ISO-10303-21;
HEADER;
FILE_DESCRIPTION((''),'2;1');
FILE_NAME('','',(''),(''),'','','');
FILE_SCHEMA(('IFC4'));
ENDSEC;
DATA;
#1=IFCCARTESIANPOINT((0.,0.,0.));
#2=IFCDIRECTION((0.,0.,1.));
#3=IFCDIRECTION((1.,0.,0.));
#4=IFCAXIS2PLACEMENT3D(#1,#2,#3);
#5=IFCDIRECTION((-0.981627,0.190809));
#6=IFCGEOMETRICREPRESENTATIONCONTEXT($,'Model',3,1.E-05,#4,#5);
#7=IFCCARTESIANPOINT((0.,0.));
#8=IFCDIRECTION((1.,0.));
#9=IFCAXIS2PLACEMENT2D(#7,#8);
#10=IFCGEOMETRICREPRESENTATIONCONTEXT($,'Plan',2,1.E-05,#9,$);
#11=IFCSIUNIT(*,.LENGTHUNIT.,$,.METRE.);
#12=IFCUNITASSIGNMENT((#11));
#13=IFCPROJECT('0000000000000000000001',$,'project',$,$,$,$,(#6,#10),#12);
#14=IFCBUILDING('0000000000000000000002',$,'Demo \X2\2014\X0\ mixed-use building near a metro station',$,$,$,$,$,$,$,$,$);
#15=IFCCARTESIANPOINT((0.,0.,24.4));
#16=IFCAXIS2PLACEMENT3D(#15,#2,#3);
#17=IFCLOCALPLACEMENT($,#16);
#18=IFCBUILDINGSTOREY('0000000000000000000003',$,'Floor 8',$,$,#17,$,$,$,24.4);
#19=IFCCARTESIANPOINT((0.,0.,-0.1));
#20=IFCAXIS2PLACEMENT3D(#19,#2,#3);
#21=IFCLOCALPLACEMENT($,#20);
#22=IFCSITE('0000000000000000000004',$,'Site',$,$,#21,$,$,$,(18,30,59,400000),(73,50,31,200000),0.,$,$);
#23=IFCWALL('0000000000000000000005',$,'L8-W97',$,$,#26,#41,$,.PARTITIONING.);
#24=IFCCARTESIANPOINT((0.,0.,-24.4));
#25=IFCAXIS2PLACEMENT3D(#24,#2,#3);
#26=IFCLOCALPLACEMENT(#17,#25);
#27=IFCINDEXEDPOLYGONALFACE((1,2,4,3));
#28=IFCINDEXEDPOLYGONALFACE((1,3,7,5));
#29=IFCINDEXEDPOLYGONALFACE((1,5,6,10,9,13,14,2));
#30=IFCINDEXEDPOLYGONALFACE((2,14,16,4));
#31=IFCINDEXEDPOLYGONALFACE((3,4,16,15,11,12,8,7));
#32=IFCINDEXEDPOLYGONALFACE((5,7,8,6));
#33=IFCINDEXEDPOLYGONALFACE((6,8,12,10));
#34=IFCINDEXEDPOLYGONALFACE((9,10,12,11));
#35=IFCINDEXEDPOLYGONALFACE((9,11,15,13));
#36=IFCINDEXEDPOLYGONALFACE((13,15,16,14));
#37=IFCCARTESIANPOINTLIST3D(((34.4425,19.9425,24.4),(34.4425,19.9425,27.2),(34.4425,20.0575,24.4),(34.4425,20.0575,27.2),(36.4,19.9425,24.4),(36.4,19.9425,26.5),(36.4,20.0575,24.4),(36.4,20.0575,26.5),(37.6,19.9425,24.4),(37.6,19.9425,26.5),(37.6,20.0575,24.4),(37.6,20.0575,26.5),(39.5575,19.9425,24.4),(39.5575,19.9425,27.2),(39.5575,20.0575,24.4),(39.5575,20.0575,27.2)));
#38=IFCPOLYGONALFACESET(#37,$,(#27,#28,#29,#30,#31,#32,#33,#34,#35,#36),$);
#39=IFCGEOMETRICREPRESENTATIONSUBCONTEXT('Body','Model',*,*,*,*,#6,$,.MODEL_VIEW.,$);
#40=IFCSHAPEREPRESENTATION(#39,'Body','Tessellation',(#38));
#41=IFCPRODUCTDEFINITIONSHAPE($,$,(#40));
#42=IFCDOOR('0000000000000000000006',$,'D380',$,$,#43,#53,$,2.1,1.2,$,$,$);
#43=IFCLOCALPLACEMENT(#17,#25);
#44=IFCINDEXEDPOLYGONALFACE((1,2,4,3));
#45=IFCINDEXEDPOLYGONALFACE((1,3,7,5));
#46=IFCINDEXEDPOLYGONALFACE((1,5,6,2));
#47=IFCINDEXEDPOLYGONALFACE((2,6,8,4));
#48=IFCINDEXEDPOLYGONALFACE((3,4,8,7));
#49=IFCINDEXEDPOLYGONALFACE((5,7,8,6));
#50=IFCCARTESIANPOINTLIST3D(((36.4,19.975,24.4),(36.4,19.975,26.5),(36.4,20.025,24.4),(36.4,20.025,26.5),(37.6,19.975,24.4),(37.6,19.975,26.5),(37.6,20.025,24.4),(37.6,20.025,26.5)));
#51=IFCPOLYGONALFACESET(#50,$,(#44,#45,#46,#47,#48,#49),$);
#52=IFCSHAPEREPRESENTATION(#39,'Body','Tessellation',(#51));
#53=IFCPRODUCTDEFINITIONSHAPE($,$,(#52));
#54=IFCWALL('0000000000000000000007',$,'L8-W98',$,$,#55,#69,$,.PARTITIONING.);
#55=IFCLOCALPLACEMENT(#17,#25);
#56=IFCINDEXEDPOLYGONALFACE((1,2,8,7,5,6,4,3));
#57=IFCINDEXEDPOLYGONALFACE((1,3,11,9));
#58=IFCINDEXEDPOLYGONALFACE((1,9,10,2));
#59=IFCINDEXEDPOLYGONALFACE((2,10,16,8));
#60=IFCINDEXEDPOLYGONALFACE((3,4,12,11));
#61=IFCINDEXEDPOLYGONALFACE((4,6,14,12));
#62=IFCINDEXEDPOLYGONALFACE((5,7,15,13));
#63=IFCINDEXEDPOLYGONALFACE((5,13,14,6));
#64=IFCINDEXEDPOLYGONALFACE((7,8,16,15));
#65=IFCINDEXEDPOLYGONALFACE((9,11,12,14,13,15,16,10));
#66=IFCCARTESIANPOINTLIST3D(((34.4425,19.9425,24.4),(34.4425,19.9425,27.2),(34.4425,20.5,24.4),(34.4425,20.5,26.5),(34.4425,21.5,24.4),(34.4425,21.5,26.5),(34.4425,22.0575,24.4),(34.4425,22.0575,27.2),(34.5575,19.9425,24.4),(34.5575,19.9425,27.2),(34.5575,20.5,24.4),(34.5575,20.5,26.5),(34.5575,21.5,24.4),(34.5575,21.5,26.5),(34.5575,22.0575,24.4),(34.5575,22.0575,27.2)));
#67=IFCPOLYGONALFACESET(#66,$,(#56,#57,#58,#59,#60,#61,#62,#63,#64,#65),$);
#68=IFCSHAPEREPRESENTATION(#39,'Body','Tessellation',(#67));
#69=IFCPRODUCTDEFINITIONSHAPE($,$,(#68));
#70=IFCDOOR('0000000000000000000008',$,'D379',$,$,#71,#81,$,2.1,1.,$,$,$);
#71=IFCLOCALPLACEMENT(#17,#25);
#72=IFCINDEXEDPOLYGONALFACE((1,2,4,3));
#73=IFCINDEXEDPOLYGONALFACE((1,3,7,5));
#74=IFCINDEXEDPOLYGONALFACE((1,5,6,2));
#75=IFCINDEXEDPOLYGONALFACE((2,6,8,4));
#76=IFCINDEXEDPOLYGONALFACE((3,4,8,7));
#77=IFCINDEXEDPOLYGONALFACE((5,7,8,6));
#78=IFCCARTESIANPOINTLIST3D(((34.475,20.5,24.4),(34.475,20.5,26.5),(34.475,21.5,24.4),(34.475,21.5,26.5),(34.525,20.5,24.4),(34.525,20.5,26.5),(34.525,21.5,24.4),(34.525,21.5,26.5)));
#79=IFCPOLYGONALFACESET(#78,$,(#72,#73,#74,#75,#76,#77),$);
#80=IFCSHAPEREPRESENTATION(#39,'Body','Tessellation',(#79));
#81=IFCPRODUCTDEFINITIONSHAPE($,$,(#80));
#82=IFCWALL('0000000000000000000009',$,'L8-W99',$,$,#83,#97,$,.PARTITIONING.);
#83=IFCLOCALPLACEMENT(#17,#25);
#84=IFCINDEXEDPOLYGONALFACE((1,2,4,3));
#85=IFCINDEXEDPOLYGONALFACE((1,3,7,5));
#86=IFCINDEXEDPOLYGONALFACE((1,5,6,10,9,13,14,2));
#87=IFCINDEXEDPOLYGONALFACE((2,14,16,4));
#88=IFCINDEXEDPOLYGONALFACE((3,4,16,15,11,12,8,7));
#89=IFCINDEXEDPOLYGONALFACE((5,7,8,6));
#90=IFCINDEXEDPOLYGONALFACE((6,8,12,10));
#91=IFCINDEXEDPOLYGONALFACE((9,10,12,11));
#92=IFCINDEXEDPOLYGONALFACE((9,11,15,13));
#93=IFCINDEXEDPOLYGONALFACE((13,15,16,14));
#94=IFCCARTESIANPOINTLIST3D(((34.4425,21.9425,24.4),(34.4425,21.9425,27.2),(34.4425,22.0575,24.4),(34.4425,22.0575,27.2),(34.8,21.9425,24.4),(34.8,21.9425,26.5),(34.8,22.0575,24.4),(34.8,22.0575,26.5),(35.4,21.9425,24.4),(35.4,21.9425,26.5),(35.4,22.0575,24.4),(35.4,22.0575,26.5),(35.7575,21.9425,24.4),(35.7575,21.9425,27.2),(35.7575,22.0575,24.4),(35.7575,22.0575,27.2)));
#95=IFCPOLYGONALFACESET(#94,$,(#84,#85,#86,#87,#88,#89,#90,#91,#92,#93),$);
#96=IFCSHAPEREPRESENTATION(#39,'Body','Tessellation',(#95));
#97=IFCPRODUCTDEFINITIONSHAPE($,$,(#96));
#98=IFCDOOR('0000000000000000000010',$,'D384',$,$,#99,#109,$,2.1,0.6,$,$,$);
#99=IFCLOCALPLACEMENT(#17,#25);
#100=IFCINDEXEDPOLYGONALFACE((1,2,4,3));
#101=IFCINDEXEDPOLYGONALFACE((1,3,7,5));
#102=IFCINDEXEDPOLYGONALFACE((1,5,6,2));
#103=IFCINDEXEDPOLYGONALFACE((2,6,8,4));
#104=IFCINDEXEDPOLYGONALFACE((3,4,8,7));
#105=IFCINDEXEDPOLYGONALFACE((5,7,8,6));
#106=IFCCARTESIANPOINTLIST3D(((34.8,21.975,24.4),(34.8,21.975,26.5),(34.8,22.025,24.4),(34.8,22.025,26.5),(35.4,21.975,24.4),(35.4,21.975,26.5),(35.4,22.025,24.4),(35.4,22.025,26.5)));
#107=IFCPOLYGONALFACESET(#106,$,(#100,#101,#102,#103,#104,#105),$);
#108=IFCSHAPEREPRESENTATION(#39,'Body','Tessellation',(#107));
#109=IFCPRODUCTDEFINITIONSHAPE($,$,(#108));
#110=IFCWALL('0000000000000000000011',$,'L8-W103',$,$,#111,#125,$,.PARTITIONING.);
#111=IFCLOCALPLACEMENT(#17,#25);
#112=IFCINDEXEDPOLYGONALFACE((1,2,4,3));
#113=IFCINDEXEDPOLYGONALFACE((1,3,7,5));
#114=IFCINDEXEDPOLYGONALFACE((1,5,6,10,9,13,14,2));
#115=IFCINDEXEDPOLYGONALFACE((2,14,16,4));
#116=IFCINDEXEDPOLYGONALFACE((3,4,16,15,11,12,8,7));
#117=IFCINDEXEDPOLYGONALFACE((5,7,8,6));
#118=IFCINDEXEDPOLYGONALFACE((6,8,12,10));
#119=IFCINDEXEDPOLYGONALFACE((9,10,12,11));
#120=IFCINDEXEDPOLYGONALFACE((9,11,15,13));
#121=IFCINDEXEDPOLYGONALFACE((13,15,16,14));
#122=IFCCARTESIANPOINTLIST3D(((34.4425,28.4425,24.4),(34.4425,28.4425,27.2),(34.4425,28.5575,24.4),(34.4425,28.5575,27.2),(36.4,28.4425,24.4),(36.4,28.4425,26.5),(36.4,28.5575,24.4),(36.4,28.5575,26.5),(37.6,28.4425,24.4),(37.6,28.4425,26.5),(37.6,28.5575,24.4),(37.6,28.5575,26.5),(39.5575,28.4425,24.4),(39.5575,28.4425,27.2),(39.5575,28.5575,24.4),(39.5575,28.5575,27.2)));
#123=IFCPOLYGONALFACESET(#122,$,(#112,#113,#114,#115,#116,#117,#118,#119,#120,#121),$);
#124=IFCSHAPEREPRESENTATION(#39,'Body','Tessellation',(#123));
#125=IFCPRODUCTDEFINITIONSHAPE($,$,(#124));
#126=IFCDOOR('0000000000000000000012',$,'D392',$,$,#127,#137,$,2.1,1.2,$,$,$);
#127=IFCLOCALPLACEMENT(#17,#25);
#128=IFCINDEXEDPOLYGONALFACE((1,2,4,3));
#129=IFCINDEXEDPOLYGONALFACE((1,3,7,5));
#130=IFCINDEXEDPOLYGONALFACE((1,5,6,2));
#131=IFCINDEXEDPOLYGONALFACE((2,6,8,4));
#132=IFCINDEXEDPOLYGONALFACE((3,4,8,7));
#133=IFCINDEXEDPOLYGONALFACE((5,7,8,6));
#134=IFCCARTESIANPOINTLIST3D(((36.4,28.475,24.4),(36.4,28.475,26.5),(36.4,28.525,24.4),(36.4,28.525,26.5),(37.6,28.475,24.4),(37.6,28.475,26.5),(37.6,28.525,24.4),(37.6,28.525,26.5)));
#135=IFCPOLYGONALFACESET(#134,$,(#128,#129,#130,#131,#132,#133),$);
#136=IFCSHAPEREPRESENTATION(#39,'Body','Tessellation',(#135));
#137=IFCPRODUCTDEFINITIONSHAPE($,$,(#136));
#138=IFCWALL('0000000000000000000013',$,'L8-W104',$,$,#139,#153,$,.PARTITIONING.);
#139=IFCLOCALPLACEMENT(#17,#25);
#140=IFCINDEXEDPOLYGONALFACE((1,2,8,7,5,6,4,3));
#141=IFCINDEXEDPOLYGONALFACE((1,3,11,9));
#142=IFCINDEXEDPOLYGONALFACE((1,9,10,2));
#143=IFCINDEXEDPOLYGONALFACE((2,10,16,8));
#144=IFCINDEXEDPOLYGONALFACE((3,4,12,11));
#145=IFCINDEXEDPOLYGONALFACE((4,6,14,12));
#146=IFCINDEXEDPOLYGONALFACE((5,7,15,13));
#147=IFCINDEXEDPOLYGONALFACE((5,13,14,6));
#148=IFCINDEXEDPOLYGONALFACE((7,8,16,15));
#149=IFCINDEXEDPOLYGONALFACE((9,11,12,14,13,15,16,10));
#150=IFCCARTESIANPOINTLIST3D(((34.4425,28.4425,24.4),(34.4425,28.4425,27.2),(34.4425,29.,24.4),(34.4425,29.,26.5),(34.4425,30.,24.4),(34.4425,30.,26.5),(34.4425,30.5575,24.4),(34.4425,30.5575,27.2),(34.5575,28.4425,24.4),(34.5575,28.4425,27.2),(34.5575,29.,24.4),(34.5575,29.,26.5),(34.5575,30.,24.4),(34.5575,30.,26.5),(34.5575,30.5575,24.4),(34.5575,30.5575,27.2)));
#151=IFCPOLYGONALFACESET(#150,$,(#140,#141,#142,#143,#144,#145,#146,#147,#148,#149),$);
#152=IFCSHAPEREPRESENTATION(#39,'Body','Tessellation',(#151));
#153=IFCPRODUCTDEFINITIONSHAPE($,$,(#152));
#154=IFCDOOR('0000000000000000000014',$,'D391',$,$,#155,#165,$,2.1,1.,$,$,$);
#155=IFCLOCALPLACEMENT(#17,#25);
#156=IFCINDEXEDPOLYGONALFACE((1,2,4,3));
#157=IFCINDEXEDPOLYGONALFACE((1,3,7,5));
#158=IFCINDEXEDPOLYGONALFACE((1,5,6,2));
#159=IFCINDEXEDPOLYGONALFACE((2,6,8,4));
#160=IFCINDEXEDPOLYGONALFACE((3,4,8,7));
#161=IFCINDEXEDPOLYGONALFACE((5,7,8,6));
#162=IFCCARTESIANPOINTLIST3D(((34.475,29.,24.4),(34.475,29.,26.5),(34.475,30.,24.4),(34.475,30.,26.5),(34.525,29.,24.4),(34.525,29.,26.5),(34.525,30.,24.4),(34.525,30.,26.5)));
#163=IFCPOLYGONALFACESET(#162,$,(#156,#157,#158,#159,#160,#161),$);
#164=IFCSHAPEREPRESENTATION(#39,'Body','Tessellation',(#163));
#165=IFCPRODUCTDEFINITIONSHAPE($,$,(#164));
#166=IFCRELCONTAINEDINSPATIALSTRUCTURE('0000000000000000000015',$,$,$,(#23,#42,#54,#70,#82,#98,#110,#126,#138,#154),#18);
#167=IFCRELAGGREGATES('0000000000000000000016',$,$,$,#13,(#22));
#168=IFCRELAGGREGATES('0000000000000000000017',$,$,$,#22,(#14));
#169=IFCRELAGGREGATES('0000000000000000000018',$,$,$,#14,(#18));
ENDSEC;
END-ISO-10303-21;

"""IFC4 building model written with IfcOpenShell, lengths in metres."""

from ifc_helpers import new_model, si_unit, direction, frame, origin_with_axes, origin_2d_with_axis, place, context, subcontext, project, spatial, line, indexed_curve, outline, extrude, element, fill, save


model = new_model("IFC4")

# Units and contexts
model_context = context("Model", 3, precision=1e-05, world=origin_with_axes(), true_north=direction((-0.981627, 0.190809)))
plan_context = context("Plan", 2, precision=1e-05, world=origin_2d_with_axis())
body_context = subcontext(model_context, "Body", "Model", "MODEL_VIEW")
ifc_project = project(units=[si_unit("LENGTHUNIT", "METRE")], contexts=[model_context, plan_context])

# Site, building, storey
site_placement = place(None, frame((0.0, 0.0, -0.1), z_axis=(0.0, 0.0, 1.0), x_axis=(1.0, 0.0, 0.0)))
site = spatial("IfcSite", under=ifc_project, at=site_placement, Name="Site", RefLatitude=(18, 30, 59, 400000), RefLongitude=(73, 50, 31, 200000), RefElevation=0.0)
building = spatial("IfcBuilding", under=site, Name="Demo — mixed-use building near a metro station")
storey_placement = place(None, frame((0.0, 0.0, 24.4), z_axis=(0.0, 0.0, 1.0), x_axis=(1.0, 0.0, 0.0)))
storey = spatial("IfcBuildingStorey", under=building, at=storey_placement, Name="Floor 8", Elevation=24.4)

# Walls, openings, doors
wall_1_placement = place(storey_placement, frame((0.0, 0.0, -24.4), z_axis=(0.0, 0.0, 1.0), x_axis=(1.0, 0.0, 0.0)))
wall_1 = element("IfcWall", 1, at=wall_1_placement, inside=storey, Name="L8-W97", PredefinedType="PARTITIONING", context=body_context, shape_type="SweptSolid", body=[
    extrude(outline(indexed_curve([(39.5575, 19.9425), (34.4425, 19.9425), (34.4425, 20.0575), (39.5575, 20.0575)], segments=[line(1, 2, 3, 4, 1)])), frame((0.0, 0.0, 24.4), z_axis=(0.0, 0.0, 1.0), x_axis=(1.0, 0.0, 0.0)), (0.0, 0.0, 1.0), 2.8),
])
opening_1_placement = place(wall_1_placement, origin_with_axes())
opening_1 = element("IfcOpeningElement", 2, at=opening_1_placement, cuts=wall_1, context=body_context, shape_type="SweptSolid", body=[
    extrude(outline(indexed_curve([(37.6, 19.8925), (36.4, 19.8925), (36.4, 20.1075), (37.6, 20.1075)], segments=[line(1, 2, 3, 4, 1)])), frame((0.0, 0.0, 24.4), z_axis=(0.0, 0.0, 1.0), x_axis=(1.0, 0.0, 0.0)), (0.0, 0.0, 1.0), 2.1),
])
door_1_placement = place(storey_placement, frame((0.0, 0.0, -24.4), z_axis=(0.0, 0.0, 1.0), x_axis=(1.0, 0.0, 0.0)))
door_1 = element("IfcDoor", 3, at=door_1_placement, inside=storey, Name="D380", OverallHeight=2.1, OverallWidth=1.2, context=body_context, shape_type="SweptSolid", body=[
    extrude(outline(indexed_curve([(37.6, 19.975), (36.4, 19.975), (36.4, 20.025), (37.6, 20.025)], segments=[line(1, 2, 3, 4, 1)])), frame((0.0, 0.0, 24.4), z_axis=(0.0, 0.0, 1.0), x_axis=(1.0, 0.0, 0.0)), (0.0, 0.0, 1.0), 2.1),
])
fill(opening_1, door_1)
wall_2_placement = place(storey_placement, frame((0.0, 0.0, -24.4), z_axis=(0.0, 0.0, 1.0), x_axis=(1.0, 0.0, 0.0)))
wall_2 = element("IfcWall", 4, at=wall_2_placement, inside=storey, Name="L8-W98", PredefinedType="PARTITIONING", context=body_context, shape_type="SweptSolid", body=[
    extrude(outline(indexed_curve([(34.4425, 19.9425), (34.4425, 22.0575), (34.5575, 22.0575), (34.5575, 19.9425)], segments=[line(1, 2, 3, 4, 1)])), frame((0.0, 0.0, 24.4), z_axis=(0.0, 0.0, 1.0), x_axis=(1.0, 0.0, 0.0)), (0.0, 0.0, 1.0), 2.8),
])
opening_2_placement = place(wall_2_placement, origin_with_axes())
opening_2 = element("IfcOpeningElement", 5, at=opening_2_placement, cuts=wall_2, context=body_context, shape_type="SweptSolid", body=[
    extrude(outline(indexed_curve([(34.3925, 20.5), (34.3925, 21.5), (34.6075, 21.5), (34.6075, 20.5)], segments=[line(1, 2, 3, 4, 1)])), frame((0.0, 0.0, 24.4), z_axis=(0.0, 0.0, 1.0), x_axis=(1.0, 0.0, 0.0)), (0.0, 0.0, 1.0), 2.1),
])
door_2_placement = place(storey_placement, frame((0.0, 0.0, -24.4), z_axis=(0.0, 0.0, 1.0), x_axis=(1.0, 0.0, 0.0)))
door_2 = element("IfcDoor", 6, at=door_2_placement, inside=storey, Name="D379", OverallHeight=2.1, OverallWidth=1.0, context=body_context, shape_type="SweptSolid", body=[
    extrude(outline(indexed_curve([(34.475, 20.5), (34.475, 21.5), (34.525, 21.5), (34.525, 20.5)], segments=[line(1, 2, 3, 4, 1)])), frame((0.0, 0.0, 24.4), z_axis=(0.0, 0.0, 1.0), x_axis=(1.0, 0.0, 0.0)), (0.0, 0.0, 1.0), 2.1),
])
fill(opening_2, door_2)
wall_3_placement = place(storey_placement, frame((0.0, 0.0, -24.4), z_axis=(0.0, 0.0, 1.0), x_axis=(1.0, 0.0, 0.0)))
wall_3 = element("IfcWall", 7, at=wall_3_placement, inside=storey, Name="L8-W99", PredefinedType="PARTITIONING", context=body_context, shape_type="SweptSolid", body=[
    extrude(outline(indexed_curve([(35.7575, 21.9425), (34.4425, 21.9425), (34.4425, 22.0575), (35.7575, 22.0575)], segments=[line(1, 2, 3, 4, 1)])), frame((0.0, 0.0, 24.4), z_axis=(0.0, 0.0, 1.0), x_axis=(1.0, 0.0, 0.0)), (0.0, 0.0, 1.0), 2.8),
])
opening_3_placement = place(wall_3_placement, origin_with_axes())
opening_3 = element("IfcOpeningElement", 8, at=opening_3_placement, cuts=wall_3, context=body_context, shape_type="SweptSolid", body=[
    extrude(outline(indexed_curve([(35.4, 21.8925), (34.8, 21.8925), (34.8, 22.1075), (35.4, 22.1075)], segments=[line(1, 2, 3, 4, 1)])), frame((0.0, 0.0, 24.4), z_axis=(0.0, 0.0, 1.0), x_axis=(1.0, 0.0, 0.0)), (0.0, 0.0, 1.0), 2.1),
])
door_3_placement = place(storey_placement, frame((0.0, 0.0, -24.4), z_axis=(0.0, 0.0, 1.0), x_axis=(1.0, 0.0, 0.0)))
door_3 = element("IfcDoor", 9, at=door_3_placement, inside=storey, Name="D384", OverallHeight=2.1, OverallWidth=0.6, context=body_context, shape_type="SweptSolid", body=[
    extrude(outline(indexed_curve([(35.4, 21.975), (34.8, 21.975), (34.8, 22.025), (35.4, 22.025)], segments=[line(1, 2, 3, 4, 1)])), frame((0.0, 0.0, 24.4), z_axis=(0.0, 0.0, 1.0), x_axis=(1.0, 0.0, 0.0)), (0.0, 0.0, 1.0), 2.1),
])
fill(opening_3, door_3)

# Walls, openings, doors
wall_4_placement = place(storey_placement, frame((0.0, 0.0, -24.4), z_axis=(0.0, 0.0, 1.0), x_axis=(1.0, 0.0, 0.0)))
wall_4 = element("IfcWall", 10, at=wall_4_placement, inside=storey, Name="L8-W103", PredefinedType="PARTITIONING", context=body_context, shape_type="SweptSolid", body=[
    extrude(outline(indexed_curve([(39.5575, 28.4425), (34.4425, 28.4425), (34.4425, 28.5575), (39.5575, 28.5575)], segments=[line(1, 2, 3, 4, 1)])), frame((0.0, 0.0, 24.4), z_axis=(0.0, 0.0, 1.0), x_axis=(1.0, 0.0, 0.0)), (0.0, 0.0, 1.0), 2.8),
])
opening_4_placement = place(wall_4_placement, origin_with_axes())
opening_4 = element("IfcOpeningElement", 11, at=opening_4_placement, cuts=wall_4, context=body_context, shape_type="SweptSolid", body=[
    extrude(outline(indexed_curve([(37.6, 28.3925), (36.4, 28.3925), (36.4, 28.6075), (37.6, 28.6075)], segments=[line(1, 2, 3, 4, 1)])), frame((0.0, 0.0, 24.4), z_axis=(0.0, 0.0, 1.0), x_axis=(1.0, 0.0, 0.0)), (0.0, 0.0, 1.0), 2.1),
])
door_4_placement = place(storey_placement, frame((0.0, 0.0, -24.4), z_axis=(0.0, 0.0, 1.0), x_axis=(1.0, 0.0, 0.0)))
door_4 = element("IfcDoor", 12, at=door_4_placement, inside=storey, Name="D392", OverallHeight=2.1, OverallWidth=1.2, context=body_context, shape_type="SweptSolid", body=[
    extrude(outline(indexed_curve([(37.6, 28.475), (36.4, 28.475), (36.4, 28.525), (37.6, 28.525)], segments=[line(1, 2, 3, 4, 1)])), frame((0.0, 0.0, 24.4), z_axis=(0.0, 0.0, 1.0), x_axis=(1.0, 0.0, 0.0)), (0.0, 0.0, 1.0), 2.1),
])
fill(opening_4, door_4)
wall_5_placement = place(storey_placement, frame((0.0, 0.0, -24.4), z_axis=(0.0, 0.0, 1.0), x_axis=(1.0, 0.0, 0.0)))
wall_5 = element("IfcWall", 13, at=wall_5_placement, inside=storey, Name="L8-W104", PredefinedType="PARTITIONING", context=body_context, shape_type="SweptSolid", body=[
    extrude(outline(indexed_curve([(34.4425, 28.4425), (34.4425, 30.5575), (34.5575, 30.5575), (34.5575, 28.4425)], segments=[line(1, 2, 3, 4, 1)])), frame((0.0, 0.0, 24.4), z_axis=(0.0, 0.0, 1.0), x_axis=(1.0, 0.0, 0.0)), (0.0, 0.0, 1.0), 2.8),
])
opening_5_placement = place(wall_5_placement, origin_with_axes())
opening_5 = element("IfcOpeningElement", 14, at=opening_5_placement, cuts=wall_5, context=body_context, shape_type="SweptSolid", body=[
    extrude(outline(indexed_curve([(34.3925, 29.0), (34.3925, 30.0), (34.6075, 30.0), (34.6075, 29.0)], segments=[line(1, 2, 3, 4, 1)])), frame((0.0, 0.0, 24.4), z_axis=(0.0, 0.0, 1.0), x_axis=(1.0, 0.0, 0.0)), (0.0, 0.0, 1.0), 2.1),
])
door_5_placement = place(storey_placement, frame((0.0, 0.0, -24.4), z_axis=(0.0, 0.0, 1.0), x_axis=(1.0, 0.0, 0.0)))
door_5 = element("IfcDoor", 15, at=door_5_placement, inside=storey, Name="D391", OverallHeight=2.1, OverallWidth=1.0, context=body_context, shape_type="SweptSolid", body=[
    extrude(outline(indexed_curve([(34.475, 29.0), (34.475, 30.0), (34.525, 30.0), (34.525, 29.0)], segments=[line(1, 2, 3, 4, 1)])), frame((0.0, 0.0, 24.4), z_axis=(0.0, 0.0, 1.0), x_axis=(1.0, 0.0, 0.0)), (0.0, 0.0, 1.0), 2.1),
])
fill(opening_5, door_5)

save(model, "model.ifc")
